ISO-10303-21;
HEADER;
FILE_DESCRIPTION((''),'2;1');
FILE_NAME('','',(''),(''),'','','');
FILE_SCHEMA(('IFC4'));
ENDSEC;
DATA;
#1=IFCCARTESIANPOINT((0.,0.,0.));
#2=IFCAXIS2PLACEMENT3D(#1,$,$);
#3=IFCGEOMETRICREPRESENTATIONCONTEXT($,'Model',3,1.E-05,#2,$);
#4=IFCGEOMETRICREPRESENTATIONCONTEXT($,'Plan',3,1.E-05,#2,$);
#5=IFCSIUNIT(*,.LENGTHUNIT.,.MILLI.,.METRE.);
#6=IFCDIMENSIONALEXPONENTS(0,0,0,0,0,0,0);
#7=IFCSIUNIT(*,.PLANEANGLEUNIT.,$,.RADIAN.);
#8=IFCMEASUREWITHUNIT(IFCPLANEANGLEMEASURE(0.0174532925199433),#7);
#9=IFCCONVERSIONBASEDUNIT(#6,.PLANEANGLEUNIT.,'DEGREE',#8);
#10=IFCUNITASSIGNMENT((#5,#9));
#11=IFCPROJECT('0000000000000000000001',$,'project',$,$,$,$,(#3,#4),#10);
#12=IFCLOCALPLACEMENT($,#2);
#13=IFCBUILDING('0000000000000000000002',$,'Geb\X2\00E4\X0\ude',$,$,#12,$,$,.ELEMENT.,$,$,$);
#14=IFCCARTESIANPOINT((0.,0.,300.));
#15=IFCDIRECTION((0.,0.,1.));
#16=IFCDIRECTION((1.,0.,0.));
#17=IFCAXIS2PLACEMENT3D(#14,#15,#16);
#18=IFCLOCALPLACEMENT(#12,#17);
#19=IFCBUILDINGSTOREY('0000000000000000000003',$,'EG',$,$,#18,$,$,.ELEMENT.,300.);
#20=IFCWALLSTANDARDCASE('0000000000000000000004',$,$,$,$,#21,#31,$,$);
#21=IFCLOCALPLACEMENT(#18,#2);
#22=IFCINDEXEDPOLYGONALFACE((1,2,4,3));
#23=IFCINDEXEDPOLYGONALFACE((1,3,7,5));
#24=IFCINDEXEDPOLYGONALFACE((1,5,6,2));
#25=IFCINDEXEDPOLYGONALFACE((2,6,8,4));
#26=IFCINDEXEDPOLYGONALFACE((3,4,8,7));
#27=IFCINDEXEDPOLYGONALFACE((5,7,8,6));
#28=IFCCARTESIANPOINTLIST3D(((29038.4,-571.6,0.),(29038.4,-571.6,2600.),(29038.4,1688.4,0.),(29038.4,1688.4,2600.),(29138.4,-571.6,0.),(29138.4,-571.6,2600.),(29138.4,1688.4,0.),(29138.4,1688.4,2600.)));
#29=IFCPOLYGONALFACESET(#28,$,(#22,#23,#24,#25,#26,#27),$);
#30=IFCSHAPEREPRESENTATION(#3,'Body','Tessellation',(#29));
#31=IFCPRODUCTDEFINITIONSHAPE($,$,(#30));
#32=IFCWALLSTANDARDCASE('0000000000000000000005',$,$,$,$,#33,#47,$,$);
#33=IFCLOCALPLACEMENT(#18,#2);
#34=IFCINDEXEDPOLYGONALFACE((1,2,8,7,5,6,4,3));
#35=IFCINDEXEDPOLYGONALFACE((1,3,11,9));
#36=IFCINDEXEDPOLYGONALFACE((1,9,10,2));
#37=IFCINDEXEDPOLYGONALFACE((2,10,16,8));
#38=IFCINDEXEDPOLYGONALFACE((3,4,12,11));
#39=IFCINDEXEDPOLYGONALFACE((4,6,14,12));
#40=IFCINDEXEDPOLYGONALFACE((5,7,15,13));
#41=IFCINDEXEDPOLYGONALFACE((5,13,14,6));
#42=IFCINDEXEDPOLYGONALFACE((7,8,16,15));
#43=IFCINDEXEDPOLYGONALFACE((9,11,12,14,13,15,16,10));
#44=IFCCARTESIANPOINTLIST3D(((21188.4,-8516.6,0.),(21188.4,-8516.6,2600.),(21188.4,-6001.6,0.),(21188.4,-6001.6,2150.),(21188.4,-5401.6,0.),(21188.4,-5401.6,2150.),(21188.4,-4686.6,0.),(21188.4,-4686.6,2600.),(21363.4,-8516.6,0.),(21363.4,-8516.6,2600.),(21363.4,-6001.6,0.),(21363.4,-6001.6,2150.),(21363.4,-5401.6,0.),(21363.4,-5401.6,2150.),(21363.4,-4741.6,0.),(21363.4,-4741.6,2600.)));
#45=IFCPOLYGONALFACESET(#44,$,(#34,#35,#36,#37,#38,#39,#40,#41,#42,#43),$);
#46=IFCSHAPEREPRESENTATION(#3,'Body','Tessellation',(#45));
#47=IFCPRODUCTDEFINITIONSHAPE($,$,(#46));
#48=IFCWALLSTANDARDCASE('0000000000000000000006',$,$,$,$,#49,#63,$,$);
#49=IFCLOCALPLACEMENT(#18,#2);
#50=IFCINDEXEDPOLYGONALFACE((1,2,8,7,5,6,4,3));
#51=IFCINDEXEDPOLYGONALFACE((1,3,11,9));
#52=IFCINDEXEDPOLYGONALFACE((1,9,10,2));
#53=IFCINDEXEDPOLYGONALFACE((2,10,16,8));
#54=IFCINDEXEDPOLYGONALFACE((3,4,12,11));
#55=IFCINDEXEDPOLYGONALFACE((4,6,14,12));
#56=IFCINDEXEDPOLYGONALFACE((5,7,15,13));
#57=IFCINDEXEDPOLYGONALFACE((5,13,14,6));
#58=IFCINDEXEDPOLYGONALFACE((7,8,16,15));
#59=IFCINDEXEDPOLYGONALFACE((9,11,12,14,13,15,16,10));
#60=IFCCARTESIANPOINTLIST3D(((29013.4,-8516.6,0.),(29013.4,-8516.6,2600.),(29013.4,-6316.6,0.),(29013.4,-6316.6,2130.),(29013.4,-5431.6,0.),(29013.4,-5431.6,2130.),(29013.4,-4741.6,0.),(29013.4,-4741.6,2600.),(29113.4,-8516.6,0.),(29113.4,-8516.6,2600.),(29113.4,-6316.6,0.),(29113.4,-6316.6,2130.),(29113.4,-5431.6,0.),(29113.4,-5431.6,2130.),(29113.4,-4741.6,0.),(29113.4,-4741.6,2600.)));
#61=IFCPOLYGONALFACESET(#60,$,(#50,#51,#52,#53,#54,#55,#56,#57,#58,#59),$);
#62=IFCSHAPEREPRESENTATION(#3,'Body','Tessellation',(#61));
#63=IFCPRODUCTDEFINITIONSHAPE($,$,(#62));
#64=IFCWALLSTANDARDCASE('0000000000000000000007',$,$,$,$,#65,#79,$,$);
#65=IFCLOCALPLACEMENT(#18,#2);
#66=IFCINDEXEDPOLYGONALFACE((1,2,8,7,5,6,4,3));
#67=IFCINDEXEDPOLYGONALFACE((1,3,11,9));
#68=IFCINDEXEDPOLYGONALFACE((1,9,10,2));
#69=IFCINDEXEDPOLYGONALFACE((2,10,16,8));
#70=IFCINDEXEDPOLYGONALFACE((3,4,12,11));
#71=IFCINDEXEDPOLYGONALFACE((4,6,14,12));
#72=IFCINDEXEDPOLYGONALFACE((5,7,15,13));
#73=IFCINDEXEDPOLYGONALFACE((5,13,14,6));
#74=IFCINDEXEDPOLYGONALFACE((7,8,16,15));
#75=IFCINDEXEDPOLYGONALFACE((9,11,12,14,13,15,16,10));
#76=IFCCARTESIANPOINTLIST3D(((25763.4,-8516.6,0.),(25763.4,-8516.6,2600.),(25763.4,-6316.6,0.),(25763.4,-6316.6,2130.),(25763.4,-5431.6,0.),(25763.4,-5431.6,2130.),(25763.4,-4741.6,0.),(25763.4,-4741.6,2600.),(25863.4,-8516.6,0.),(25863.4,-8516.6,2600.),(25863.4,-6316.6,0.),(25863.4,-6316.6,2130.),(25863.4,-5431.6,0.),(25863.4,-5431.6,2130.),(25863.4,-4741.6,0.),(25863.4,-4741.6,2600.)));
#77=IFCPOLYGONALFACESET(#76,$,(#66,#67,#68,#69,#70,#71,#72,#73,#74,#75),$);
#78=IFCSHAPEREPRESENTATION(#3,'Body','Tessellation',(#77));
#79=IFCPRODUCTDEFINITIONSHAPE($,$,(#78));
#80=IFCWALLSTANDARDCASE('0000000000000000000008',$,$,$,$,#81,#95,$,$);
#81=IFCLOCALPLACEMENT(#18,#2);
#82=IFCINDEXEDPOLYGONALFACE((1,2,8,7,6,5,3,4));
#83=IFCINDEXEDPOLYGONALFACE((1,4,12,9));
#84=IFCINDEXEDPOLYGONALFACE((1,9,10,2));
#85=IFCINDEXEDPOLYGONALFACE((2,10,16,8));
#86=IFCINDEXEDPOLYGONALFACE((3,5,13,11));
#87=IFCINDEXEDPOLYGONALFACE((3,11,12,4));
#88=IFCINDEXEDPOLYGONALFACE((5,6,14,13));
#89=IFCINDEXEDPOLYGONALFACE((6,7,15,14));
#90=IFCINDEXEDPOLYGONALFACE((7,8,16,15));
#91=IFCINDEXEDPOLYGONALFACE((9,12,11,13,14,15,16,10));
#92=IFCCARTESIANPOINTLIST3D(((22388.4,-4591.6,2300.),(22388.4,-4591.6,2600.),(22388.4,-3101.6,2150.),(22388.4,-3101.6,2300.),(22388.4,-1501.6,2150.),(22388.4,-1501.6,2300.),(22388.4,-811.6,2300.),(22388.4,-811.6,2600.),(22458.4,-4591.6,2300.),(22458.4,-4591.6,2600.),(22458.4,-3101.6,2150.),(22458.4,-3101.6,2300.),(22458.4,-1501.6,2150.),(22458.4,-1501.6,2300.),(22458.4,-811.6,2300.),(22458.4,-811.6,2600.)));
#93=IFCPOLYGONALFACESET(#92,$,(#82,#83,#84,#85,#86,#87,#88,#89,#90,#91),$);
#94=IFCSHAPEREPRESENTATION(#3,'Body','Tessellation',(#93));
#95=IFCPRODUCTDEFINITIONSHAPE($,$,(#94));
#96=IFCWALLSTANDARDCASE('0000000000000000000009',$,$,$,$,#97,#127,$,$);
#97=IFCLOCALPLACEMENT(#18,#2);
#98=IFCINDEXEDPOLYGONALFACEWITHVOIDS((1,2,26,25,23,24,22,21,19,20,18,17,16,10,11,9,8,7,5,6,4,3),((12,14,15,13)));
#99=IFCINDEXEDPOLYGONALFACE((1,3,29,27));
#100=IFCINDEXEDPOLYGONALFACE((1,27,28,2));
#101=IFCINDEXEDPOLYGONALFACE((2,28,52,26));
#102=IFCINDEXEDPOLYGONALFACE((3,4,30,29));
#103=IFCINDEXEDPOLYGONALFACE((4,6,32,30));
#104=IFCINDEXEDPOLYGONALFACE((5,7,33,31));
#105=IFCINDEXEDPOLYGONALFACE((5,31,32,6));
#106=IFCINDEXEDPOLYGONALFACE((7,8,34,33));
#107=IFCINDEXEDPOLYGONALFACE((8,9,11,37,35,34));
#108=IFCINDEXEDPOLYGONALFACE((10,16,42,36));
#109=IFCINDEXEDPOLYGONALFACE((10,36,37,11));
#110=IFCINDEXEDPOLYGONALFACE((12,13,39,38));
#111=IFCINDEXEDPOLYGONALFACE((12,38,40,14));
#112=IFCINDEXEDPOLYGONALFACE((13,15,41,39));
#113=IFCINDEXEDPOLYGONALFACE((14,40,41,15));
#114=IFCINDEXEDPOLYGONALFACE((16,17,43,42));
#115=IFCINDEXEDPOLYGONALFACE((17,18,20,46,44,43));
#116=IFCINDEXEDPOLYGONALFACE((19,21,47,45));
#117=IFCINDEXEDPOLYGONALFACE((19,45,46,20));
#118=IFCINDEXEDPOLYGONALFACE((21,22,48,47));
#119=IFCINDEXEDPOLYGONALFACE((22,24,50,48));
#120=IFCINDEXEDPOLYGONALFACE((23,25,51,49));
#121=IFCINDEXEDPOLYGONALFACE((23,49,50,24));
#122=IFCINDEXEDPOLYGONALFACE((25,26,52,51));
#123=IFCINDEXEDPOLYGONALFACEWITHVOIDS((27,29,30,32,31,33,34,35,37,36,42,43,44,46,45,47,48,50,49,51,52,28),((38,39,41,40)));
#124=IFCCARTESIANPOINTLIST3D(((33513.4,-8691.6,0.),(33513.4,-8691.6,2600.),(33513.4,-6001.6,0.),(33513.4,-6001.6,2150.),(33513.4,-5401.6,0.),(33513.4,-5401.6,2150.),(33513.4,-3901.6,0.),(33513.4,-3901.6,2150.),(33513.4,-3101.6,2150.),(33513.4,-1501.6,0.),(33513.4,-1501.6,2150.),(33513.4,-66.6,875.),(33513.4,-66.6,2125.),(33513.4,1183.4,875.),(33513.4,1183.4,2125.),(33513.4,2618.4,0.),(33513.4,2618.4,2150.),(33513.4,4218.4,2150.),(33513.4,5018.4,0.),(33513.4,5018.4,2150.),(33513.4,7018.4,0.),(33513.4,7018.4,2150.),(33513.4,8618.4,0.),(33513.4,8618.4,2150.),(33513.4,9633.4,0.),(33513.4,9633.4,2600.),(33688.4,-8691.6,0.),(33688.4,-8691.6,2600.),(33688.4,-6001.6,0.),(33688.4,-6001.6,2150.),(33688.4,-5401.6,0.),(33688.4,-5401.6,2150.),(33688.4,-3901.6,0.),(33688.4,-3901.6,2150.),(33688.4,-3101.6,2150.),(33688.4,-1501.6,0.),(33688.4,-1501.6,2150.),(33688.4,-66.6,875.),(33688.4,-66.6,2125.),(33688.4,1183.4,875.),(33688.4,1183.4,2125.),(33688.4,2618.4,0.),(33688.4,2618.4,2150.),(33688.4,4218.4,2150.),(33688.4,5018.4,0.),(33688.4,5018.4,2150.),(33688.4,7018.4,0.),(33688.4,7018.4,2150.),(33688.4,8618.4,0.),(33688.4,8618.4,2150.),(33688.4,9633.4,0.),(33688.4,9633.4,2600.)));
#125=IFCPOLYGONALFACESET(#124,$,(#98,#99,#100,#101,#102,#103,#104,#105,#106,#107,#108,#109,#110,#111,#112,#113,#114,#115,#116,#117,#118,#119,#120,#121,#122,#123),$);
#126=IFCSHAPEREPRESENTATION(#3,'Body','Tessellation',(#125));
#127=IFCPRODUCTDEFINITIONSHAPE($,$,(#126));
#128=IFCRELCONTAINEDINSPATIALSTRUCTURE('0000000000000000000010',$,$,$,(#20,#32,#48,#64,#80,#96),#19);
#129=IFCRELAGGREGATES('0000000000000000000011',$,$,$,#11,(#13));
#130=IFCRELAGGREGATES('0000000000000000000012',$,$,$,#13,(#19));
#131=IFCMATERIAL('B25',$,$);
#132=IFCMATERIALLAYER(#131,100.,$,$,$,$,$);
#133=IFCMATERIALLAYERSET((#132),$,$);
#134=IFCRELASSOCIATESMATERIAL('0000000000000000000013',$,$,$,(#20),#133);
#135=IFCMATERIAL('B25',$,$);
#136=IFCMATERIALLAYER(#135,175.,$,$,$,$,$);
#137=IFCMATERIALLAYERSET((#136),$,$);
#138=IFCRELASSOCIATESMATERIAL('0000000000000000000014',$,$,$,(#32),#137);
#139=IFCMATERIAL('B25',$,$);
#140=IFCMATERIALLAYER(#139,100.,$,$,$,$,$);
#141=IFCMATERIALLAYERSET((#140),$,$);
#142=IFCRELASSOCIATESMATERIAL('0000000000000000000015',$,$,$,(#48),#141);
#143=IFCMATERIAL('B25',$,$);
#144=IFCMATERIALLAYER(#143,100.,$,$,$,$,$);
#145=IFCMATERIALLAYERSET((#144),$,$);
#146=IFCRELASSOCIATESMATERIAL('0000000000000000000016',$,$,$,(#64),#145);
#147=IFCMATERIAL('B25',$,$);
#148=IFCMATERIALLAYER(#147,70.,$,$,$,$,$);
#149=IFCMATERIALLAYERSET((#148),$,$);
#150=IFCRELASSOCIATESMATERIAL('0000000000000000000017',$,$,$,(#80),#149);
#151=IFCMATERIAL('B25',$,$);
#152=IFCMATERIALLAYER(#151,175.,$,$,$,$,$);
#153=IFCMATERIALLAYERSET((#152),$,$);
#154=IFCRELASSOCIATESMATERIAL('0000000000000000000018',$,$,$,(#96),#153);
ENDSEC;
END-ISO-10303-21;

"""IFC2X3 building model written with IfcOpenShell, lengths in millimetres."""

from ifc_helpers import new_model, entity, si_unit, converted_unit, frame, frame_2d, origin, origin_with_axes, place, context, project, spatial, polyline, rectangle, outline, extrude, material, layer, layer_set, layer_usage, element, save


model = new_model("IFC2X3")

# Units and contexts
model_context = context("Model", 3, precision=1e-05, world=origin())
plan_context = context("Plan", 3, precision=1e-05, world=origin())
ifc_project = project(units=[si_unit("LENGTHUNIT", "METRE", prefix="MILLI"), converted_unit("PLANEANGLEUNIT", "DEGREE", entity("IfcPlaneAngleMeasure", 0.0174532925199433), si_unit("PLANEANGLEUNIT", "RADIAN"), dimensions=[0, 0, 0, 0, 0, 0, 0])], contexts=[model_context, plan_context])

# Building, storey
building_placement = place(None, origin())
building = spatial("IfcBuilding", under=ifc_project, at=building_placement, Name="Gebäude", CompositionType="ELEMENT")
storey_placement = place(building_placement, frame((0.0, 0.0, 300.0), z_axis=(0.0, 0.0, 1.0), x_axis=(1.0, 0.0, 0.0)))
storey = spatial("IfcBuildingStorey", under=building, at=storey_placement, Name="EG", CompositionType="ELEMENT", Elevation=300.0)

# Wall
ifc_material_1 = material(Name="B25")
ifc_layer_1 = layer(ifc_material_1, 100.0)
ifc_layer_set_1 = layer_set([ifc_layer_1])
ifc_layer_usage_1 = layer_usage(ifc_layer_set_1, "AXIS2", "POSITIVE", 0.0)
wall_1_placement = place(storey_placement, frame((29138.4, -571.6, 0.0), z_axis=(0.0, 0.0, 1.0), x_axis=(0.0, 1.0, 0.0)))
element("IfcWallStandardCase", 1, at=wall_1_placement, inside=storey, material=ifc_layer_usage_1, context=model_context, shape_type="SweptSolid", body=[
    extrude(rectangle(XDim=2260.0, YDim=100.0, at=frame_2d((1130.0, 50.0), x_axis=(1.0, 0.0))), origin_with_axes(), (0.0, 0.0, 1.0), 2600.0),
])

# Walls, openings
ifc_material_2 = material(Name="B25")
ifc_layer_2 = layer(ifc_material_2, 175.0)
ifc_layer_set_2 = layer_set([ifc_layer_2])
ifc_layer_usage_2 = layer_usage(ifc_layer_set_2, "AXIS2", "POSITIVE", 0.0)
wall_2_placement = place(storey_placement, frame((21188.4, -4686.6, 0.0), z_axis=(0.0, 0.0, 1.0), x_axis=(0.0, -1.0, 0.0)))
wall_2 = element("IfcWallStandardCase", 2, at=wall_2_placement, inside=storey, material=ifc_layer_usage_2, context=model_context, shape_type="SweptSolid", body=[
    extrude(outline(polyline([(0.0, 0.0), (3830.0, 0.0), (3830.0, 175.0), (55.0, 175.0), (0.0, 0.0)])), origin_with_axes(), (0.0, 0.0, 1.0), 2600.0),
])
opening_1_placement = place(wall_2_placement, frame((715.0, 0.0, 0.0), z_axis=(0.0, 1.0, 0.0), x_axis=(0.0, 0.0, 1.0)))
element("IfcOpeningElement", 3, at=opening_1_placement, cuts=wall_2, ObjectType="Opening", context=model_context, shape_type="SweptSolid", body=[
    extrude(rectangle(XDim=2150.0, YDim=600.0, at=frame_2d((1075.0, 300.0), x_axis=(1.0, 0.0))), origin_with_axes(), (0.0, 0.0, 1.0), 175.0),
])
ifc_material_3 = material(Name="B25")
ifc_layer_3 = layer(ifc_material_3, 100.0)
ifc_layer_set_3 = layer_set([ifc_layer_3])
ifc_layer_usage_3 = layer_usage(ifc_layer_set_3, "AXIS2", "POSITIVE", 0.0)
wall_3_placement = place(storey_placement, frame((29113.4, -8516.6, 0.0), z_axis=(0.0, 0.0, 1.0), x_axis=(0.0, 1.0, 0.0)))
wall_3 = element("IfcWallStandardCase", 4, at=wall_3_placement, inside=storey, material=ifc_layer_usage_3, context=model_context, shape_type="SweptSolid", body=[
    extrude(rectangle(XDim=3775.0, YDim=100.0, at=frame_2d((1887.5, 50.0), x_axis=(1.0, 0.0))), origin_with_axes(), (0.0, 0.0, 1.0), 2600.0),
])
opening_2_placement = place(wall_3_placement, frame((2200.0, 0.0, 0.0), z_axis=(0.0, 1.0, 0.0), x_axis=(0.0, 0.0, 1.0)))
element("IfcOpeningElement", 5, at=opening_2_placement, cuts=wall_3, ObjectType="Opening", context=model_context, shape_type="SweptSolid", body=[
    extrude(rectangle(XDim=2130.0, YDim=885.0, at=frame_2d((1065.0, 442.5), x_axis=(1.0, 0.0))), origin_with_axes(), (0.0, 0.0, 1.0), 100.0),
])
ifc_material_4 = material(Name="B25")
ifc_layer_4 = layer(ifc_material_4, 100.0)
ifc_layer_set_4 = layer_set([ifc_layer_4])
ifc_layer_usage_4 = layer_usage(ifc_layer_set_4, "AXIS2", "POSITIVE", 0.0)
wall_4_placement = place(storey_placement, frame((25763.4, -4741.6, 0.0), z_axis=(0.0, 0.0, 1.0), x_axis=(0.0, -1.0, 0.0)))
wall_4 = element("IfcWallStandardCase", 6, at=wall_4_placement, inside=storey, material=ifc_layer_usage_4, context=model_context, shape_type="SweptSolid", body=[
    extrude(rectangle(XDim=3775.0, YDim=100.0, at=frame_2d((1887.5, 50.0), x_axis=(1.0, 0.0))), origin_with_axes(), (0.0, 0.0, 1.0), 2600.0),
])
opening_3_placement = place(wall_4_placement, frame((690.0, 0.0, 0.0), z_axis=(0.0, 1.0, 0.0), x_axis=(0.0, 0.0, 1.0)))
element("IfcOpeningElement", 7, at=opening_3_placement, cuts=wall_4, ObjectType="Opening", context=model_context, shape_type="SweptSolid", body=[
    extrude(rectangle(XDim=2130.0, YDim=885.0, at=frame_2d((1065.0, 442.5), x_axis=(1.0, 0.0))), origin_with_axes(), (0.0, 0.0, 1.0), 100.0),
])

# Walls, openings
ifc_material_5 = material(Name="B25")
ifc_layer_5 = layer(ifc_material_5, 70.0)
ifc_layer_set_5 = layer_set([ifc_layer_5])
ifc_layer_usage_5 = layer_usage(ifc_layer_set_5, "AXIS2", "POSITIVE", 0.0)
wall_5_placement = place(storey_placement, frame((22458.4, -4591.6, 0.0), z_axis=(0.0, 0.0, 1.0), x_axis=(0.0, 1.0, 0.0)))
wall_5 = element("IfcWallStandardCase", 8, at=wall_5_placement, inside=storey, material=ifc_layer_usage_5, context=model_context, shape_type="SweptSolid", body=[
    extrude(rectangle(XDim=3780.0, YDim=70.0, at=frame_2d((1890.0, 35.0), x_axis=(1.0, 0.0))), origin_with_axes(), (0.0, 0.0, 1.0), 2600.0),
])
opening_4_placement = place(wall_5_placement, frame((1490.0, 0.0, 0.0), z_axis=(0.0, 1.0, 0.0), x_axis=(0.0, 0.0, 1.0)))
element("IfcOpeningElement", 9, at=opening_4_placement, cuts=wall_5, ObjectType="Opening", context=model_context, shape_type="SweptSolid", body=[
    extrude(rectangle(XDim=2150.0, YDim=1600.0, at=frame_2d((1075.0, 800.0), x_axis=(1.0, 0.0))), origin_with_axes(), (0.0, 0.0, 1.0), 70.0),
])
opening_5_placement = place(wall_5_placement, frame((3090.0, 0.0, 0.0), z_axis=(0.0, 1.0, 0.0), x_axis=(0.0, 0.0, 1.0)))
element("IfcOpeningElement", 10, at=opening_5_placement, cuts=wall_5, ObjectType="Opening", context=model_context, shape_type="SweptSolid", body=[
    extrude(rectangle(XDim=2300.0, YDim=690.0, at=frame_2d((1150.0, 345.0), x_axis=(1.0, 0.0))), origin_with_axes(), (0.0, 0.0, 1.0), 70.0),
])
opening_6_placement = place(wall_5_placement, frame((0.0, 0.0, 0.0), z_axis=(0.0, 1.0, 0.0), x_axis=(0.0, 0.0, 1.0)))
element("IfcOpeningElement", 11, at=opening_6_placement, cuts=wall_5, ObjectType="Opening", context=model_context, shape_type="SweptSolid", body=[
    extrude(rectangle(XDim=2300.0, YDim=1490.0, at=frame_2d((1150.0, 745.0), x_axis=(1.0, 0.0))), origin_with_axes(), (0.0, 0.0, 1.0), 70.0),
])
ifc_material_6 = material(Name="B25")
ifc_layer_6 = layer(ifc_material_6, 175.0)
ifc_layer_set_6 = layer_set([ifc_layer_6])
ifc_layer_usage_6 = layer_usage(ifc_layer_set_6, "AXIS2", "POSITIVE", 0.0)
wall_6_placement = place(storey_placement, frame((33688.4, -8691.6, 0.0), z_axis=(0.0, 0.0, 1.0), x_axis=(0.0, 1.0, 0.0)))
wall_6 = element("IfcWallStandardCase", 12, at=wall_6_placement, inside=storey, material=ifc_layer_usage_6, context=model_context, shape_type="SweptSolid", body=[
    extrude(rectangle(XDim=18325.0, YDim=175.0, at=frame_2d((9162.5, 87.5), x_axis=(1.0, 0.0))), origin_with_axes(), (0.0, 0.0, 1.0), 2600.0),
])
opening_7_placement = place(wall_6_placement, frame((15710.0, 0.0, 0.0), z_axis=(0.0, 1.0, 0.0), x_axis=(0.0, 0.0, 1.0)))
element("IfcOpeningElement", 13, at=opening_7_placement, cuts=wall_6, ObjectType="Opening", context=model_context, shape_type="SweptSolid", body=[
    extrude(rectangle(XDim=2150.0, YDim=1600.0, at=frame_2d((1075.0, 800.0), x_axis=(1.0, 0.0))), origin_with_axes(), (0.0, 0.0, 1.0), 175.0),
])
opening_8_placement = place(wall_6_placement, frame((2690.0, 0.0, 0.0), z_axis=(0.0, 1.0, 0.0), x_axis=(0.0, 0.0, 1.0)))
element("IfcOpeningElement", 14, at=opening_8_placement, cuts=wall_6, ObjectType="Opening", context=model_context, shape_type="SweptSolid", body=[
    extrude(rectangle(XDim=2150.0, YDim=600.0, at=frame_2d((1075.0, 300.0), x_axis=(1.0, 0.0))), origin_with_axes(), (0.0, 0.0, 1.0), 175.0),
])
opening_9_placement = place(wall_6_placement, frame((8625.0, 0.0, 875.0), z_axis=(0.0, 1.0, 0.0), x_axis=(0.0, 0.0, 1.0)))
element("IfcOpeningElement", 15, at=opening_9_placement, cuts=wall_6, ObjectType="Opening", context=model_context, shape_type="SweptSolid", body=[
    extrude(rectangle(XDim=1250.0, YDim=1250.0, at=frame_2d((625.0, 625.0), x_axis=(1.0, 0.0))), origin_with_axes(), (0.0, 0.0, 1.0), 175.0),
])
opening_10_placement = place(wall_6_placement, frame((4790.0, 0.0, 0.0), z_axis=(0.0, 1.0, 0.0), x_axis=(0.0, 0.0, 1.0)))
element("IfcOpeningElement", 16, at=opening_10_placement, cuts=wall_6, ObjectType="Opening", context=model_context, shape_type="SweptSolid", body=[
    extrude(rectangle(XDim=2150.0, YDim=800.0, at=frame_2d((1075.0, 400.0), x_axis=(1.0, 0.0))), origin_with_axes(), (0.0, 0.0, 1.0), 175.0),
])
opening_11_placement = place(wall_6_placement, frame((5590.0, 0.0, 0.0), z_axis=(0.0, 1.0, 0.0), x_axis=(0.0, 0.0, 1.0)))
element("IfcOpeningElement", 17, at=opening_11_placement, cuts=wall_6, ObjectType="Opening", context=model_context, shape_type="SweptSolid", body=[
    extrude(rectangle(XDim=2150.0, YDim=1600.0, at=frame_2d((1075.0, 800.0), x_axis=(1.0, 0.0))), origin_with_axes(), (0.0, 0.0, 1.0), 175.0),
])
opening_12_placement = place(wall_6_placement, frame((12910.0, 0.0, 0.0), z_axis=(0.0, 1.0, 0.0), x_axis=(0.0, 0.0, 1.0)))
element("IfcOpeningElement", 18, at=opening_12_placement, cuts=wall_6, ObjectType="Opening", context=model_context, shape_type="SweptSolid", body=[
    extrude(rectangle(XDim=2150.0, YDim=800.0, at=frame_2d((1075.0, 400.0), x_axis=(1.0, 0.0))), origin_with_axes(), (0.0, 0.0, 1.0), 175.0),
])
opening_13_placement = place(wall_6_placement, frame((11310.0, 0.0, 0.0), z_axis=(0.0, 1.0, 0.0), x_axis=(0.0, 0.0, 1.0)))
element("IfcOpeningElement", 19, at=opening_13_placement, cuts=wall_6, ObjectType="Opening", context=model_context, shape_type="SweptSolid", body=[
    extrude(rectangle(XDim=2150.0, YDim=1600.0, at=frame_2d((1075.0, 800.0), x_axis=(1.0, 0.0))), origin_with_axes(), (0.0, 0.0, 1.0), 175.0),
])

save(model, "model.ifc")
